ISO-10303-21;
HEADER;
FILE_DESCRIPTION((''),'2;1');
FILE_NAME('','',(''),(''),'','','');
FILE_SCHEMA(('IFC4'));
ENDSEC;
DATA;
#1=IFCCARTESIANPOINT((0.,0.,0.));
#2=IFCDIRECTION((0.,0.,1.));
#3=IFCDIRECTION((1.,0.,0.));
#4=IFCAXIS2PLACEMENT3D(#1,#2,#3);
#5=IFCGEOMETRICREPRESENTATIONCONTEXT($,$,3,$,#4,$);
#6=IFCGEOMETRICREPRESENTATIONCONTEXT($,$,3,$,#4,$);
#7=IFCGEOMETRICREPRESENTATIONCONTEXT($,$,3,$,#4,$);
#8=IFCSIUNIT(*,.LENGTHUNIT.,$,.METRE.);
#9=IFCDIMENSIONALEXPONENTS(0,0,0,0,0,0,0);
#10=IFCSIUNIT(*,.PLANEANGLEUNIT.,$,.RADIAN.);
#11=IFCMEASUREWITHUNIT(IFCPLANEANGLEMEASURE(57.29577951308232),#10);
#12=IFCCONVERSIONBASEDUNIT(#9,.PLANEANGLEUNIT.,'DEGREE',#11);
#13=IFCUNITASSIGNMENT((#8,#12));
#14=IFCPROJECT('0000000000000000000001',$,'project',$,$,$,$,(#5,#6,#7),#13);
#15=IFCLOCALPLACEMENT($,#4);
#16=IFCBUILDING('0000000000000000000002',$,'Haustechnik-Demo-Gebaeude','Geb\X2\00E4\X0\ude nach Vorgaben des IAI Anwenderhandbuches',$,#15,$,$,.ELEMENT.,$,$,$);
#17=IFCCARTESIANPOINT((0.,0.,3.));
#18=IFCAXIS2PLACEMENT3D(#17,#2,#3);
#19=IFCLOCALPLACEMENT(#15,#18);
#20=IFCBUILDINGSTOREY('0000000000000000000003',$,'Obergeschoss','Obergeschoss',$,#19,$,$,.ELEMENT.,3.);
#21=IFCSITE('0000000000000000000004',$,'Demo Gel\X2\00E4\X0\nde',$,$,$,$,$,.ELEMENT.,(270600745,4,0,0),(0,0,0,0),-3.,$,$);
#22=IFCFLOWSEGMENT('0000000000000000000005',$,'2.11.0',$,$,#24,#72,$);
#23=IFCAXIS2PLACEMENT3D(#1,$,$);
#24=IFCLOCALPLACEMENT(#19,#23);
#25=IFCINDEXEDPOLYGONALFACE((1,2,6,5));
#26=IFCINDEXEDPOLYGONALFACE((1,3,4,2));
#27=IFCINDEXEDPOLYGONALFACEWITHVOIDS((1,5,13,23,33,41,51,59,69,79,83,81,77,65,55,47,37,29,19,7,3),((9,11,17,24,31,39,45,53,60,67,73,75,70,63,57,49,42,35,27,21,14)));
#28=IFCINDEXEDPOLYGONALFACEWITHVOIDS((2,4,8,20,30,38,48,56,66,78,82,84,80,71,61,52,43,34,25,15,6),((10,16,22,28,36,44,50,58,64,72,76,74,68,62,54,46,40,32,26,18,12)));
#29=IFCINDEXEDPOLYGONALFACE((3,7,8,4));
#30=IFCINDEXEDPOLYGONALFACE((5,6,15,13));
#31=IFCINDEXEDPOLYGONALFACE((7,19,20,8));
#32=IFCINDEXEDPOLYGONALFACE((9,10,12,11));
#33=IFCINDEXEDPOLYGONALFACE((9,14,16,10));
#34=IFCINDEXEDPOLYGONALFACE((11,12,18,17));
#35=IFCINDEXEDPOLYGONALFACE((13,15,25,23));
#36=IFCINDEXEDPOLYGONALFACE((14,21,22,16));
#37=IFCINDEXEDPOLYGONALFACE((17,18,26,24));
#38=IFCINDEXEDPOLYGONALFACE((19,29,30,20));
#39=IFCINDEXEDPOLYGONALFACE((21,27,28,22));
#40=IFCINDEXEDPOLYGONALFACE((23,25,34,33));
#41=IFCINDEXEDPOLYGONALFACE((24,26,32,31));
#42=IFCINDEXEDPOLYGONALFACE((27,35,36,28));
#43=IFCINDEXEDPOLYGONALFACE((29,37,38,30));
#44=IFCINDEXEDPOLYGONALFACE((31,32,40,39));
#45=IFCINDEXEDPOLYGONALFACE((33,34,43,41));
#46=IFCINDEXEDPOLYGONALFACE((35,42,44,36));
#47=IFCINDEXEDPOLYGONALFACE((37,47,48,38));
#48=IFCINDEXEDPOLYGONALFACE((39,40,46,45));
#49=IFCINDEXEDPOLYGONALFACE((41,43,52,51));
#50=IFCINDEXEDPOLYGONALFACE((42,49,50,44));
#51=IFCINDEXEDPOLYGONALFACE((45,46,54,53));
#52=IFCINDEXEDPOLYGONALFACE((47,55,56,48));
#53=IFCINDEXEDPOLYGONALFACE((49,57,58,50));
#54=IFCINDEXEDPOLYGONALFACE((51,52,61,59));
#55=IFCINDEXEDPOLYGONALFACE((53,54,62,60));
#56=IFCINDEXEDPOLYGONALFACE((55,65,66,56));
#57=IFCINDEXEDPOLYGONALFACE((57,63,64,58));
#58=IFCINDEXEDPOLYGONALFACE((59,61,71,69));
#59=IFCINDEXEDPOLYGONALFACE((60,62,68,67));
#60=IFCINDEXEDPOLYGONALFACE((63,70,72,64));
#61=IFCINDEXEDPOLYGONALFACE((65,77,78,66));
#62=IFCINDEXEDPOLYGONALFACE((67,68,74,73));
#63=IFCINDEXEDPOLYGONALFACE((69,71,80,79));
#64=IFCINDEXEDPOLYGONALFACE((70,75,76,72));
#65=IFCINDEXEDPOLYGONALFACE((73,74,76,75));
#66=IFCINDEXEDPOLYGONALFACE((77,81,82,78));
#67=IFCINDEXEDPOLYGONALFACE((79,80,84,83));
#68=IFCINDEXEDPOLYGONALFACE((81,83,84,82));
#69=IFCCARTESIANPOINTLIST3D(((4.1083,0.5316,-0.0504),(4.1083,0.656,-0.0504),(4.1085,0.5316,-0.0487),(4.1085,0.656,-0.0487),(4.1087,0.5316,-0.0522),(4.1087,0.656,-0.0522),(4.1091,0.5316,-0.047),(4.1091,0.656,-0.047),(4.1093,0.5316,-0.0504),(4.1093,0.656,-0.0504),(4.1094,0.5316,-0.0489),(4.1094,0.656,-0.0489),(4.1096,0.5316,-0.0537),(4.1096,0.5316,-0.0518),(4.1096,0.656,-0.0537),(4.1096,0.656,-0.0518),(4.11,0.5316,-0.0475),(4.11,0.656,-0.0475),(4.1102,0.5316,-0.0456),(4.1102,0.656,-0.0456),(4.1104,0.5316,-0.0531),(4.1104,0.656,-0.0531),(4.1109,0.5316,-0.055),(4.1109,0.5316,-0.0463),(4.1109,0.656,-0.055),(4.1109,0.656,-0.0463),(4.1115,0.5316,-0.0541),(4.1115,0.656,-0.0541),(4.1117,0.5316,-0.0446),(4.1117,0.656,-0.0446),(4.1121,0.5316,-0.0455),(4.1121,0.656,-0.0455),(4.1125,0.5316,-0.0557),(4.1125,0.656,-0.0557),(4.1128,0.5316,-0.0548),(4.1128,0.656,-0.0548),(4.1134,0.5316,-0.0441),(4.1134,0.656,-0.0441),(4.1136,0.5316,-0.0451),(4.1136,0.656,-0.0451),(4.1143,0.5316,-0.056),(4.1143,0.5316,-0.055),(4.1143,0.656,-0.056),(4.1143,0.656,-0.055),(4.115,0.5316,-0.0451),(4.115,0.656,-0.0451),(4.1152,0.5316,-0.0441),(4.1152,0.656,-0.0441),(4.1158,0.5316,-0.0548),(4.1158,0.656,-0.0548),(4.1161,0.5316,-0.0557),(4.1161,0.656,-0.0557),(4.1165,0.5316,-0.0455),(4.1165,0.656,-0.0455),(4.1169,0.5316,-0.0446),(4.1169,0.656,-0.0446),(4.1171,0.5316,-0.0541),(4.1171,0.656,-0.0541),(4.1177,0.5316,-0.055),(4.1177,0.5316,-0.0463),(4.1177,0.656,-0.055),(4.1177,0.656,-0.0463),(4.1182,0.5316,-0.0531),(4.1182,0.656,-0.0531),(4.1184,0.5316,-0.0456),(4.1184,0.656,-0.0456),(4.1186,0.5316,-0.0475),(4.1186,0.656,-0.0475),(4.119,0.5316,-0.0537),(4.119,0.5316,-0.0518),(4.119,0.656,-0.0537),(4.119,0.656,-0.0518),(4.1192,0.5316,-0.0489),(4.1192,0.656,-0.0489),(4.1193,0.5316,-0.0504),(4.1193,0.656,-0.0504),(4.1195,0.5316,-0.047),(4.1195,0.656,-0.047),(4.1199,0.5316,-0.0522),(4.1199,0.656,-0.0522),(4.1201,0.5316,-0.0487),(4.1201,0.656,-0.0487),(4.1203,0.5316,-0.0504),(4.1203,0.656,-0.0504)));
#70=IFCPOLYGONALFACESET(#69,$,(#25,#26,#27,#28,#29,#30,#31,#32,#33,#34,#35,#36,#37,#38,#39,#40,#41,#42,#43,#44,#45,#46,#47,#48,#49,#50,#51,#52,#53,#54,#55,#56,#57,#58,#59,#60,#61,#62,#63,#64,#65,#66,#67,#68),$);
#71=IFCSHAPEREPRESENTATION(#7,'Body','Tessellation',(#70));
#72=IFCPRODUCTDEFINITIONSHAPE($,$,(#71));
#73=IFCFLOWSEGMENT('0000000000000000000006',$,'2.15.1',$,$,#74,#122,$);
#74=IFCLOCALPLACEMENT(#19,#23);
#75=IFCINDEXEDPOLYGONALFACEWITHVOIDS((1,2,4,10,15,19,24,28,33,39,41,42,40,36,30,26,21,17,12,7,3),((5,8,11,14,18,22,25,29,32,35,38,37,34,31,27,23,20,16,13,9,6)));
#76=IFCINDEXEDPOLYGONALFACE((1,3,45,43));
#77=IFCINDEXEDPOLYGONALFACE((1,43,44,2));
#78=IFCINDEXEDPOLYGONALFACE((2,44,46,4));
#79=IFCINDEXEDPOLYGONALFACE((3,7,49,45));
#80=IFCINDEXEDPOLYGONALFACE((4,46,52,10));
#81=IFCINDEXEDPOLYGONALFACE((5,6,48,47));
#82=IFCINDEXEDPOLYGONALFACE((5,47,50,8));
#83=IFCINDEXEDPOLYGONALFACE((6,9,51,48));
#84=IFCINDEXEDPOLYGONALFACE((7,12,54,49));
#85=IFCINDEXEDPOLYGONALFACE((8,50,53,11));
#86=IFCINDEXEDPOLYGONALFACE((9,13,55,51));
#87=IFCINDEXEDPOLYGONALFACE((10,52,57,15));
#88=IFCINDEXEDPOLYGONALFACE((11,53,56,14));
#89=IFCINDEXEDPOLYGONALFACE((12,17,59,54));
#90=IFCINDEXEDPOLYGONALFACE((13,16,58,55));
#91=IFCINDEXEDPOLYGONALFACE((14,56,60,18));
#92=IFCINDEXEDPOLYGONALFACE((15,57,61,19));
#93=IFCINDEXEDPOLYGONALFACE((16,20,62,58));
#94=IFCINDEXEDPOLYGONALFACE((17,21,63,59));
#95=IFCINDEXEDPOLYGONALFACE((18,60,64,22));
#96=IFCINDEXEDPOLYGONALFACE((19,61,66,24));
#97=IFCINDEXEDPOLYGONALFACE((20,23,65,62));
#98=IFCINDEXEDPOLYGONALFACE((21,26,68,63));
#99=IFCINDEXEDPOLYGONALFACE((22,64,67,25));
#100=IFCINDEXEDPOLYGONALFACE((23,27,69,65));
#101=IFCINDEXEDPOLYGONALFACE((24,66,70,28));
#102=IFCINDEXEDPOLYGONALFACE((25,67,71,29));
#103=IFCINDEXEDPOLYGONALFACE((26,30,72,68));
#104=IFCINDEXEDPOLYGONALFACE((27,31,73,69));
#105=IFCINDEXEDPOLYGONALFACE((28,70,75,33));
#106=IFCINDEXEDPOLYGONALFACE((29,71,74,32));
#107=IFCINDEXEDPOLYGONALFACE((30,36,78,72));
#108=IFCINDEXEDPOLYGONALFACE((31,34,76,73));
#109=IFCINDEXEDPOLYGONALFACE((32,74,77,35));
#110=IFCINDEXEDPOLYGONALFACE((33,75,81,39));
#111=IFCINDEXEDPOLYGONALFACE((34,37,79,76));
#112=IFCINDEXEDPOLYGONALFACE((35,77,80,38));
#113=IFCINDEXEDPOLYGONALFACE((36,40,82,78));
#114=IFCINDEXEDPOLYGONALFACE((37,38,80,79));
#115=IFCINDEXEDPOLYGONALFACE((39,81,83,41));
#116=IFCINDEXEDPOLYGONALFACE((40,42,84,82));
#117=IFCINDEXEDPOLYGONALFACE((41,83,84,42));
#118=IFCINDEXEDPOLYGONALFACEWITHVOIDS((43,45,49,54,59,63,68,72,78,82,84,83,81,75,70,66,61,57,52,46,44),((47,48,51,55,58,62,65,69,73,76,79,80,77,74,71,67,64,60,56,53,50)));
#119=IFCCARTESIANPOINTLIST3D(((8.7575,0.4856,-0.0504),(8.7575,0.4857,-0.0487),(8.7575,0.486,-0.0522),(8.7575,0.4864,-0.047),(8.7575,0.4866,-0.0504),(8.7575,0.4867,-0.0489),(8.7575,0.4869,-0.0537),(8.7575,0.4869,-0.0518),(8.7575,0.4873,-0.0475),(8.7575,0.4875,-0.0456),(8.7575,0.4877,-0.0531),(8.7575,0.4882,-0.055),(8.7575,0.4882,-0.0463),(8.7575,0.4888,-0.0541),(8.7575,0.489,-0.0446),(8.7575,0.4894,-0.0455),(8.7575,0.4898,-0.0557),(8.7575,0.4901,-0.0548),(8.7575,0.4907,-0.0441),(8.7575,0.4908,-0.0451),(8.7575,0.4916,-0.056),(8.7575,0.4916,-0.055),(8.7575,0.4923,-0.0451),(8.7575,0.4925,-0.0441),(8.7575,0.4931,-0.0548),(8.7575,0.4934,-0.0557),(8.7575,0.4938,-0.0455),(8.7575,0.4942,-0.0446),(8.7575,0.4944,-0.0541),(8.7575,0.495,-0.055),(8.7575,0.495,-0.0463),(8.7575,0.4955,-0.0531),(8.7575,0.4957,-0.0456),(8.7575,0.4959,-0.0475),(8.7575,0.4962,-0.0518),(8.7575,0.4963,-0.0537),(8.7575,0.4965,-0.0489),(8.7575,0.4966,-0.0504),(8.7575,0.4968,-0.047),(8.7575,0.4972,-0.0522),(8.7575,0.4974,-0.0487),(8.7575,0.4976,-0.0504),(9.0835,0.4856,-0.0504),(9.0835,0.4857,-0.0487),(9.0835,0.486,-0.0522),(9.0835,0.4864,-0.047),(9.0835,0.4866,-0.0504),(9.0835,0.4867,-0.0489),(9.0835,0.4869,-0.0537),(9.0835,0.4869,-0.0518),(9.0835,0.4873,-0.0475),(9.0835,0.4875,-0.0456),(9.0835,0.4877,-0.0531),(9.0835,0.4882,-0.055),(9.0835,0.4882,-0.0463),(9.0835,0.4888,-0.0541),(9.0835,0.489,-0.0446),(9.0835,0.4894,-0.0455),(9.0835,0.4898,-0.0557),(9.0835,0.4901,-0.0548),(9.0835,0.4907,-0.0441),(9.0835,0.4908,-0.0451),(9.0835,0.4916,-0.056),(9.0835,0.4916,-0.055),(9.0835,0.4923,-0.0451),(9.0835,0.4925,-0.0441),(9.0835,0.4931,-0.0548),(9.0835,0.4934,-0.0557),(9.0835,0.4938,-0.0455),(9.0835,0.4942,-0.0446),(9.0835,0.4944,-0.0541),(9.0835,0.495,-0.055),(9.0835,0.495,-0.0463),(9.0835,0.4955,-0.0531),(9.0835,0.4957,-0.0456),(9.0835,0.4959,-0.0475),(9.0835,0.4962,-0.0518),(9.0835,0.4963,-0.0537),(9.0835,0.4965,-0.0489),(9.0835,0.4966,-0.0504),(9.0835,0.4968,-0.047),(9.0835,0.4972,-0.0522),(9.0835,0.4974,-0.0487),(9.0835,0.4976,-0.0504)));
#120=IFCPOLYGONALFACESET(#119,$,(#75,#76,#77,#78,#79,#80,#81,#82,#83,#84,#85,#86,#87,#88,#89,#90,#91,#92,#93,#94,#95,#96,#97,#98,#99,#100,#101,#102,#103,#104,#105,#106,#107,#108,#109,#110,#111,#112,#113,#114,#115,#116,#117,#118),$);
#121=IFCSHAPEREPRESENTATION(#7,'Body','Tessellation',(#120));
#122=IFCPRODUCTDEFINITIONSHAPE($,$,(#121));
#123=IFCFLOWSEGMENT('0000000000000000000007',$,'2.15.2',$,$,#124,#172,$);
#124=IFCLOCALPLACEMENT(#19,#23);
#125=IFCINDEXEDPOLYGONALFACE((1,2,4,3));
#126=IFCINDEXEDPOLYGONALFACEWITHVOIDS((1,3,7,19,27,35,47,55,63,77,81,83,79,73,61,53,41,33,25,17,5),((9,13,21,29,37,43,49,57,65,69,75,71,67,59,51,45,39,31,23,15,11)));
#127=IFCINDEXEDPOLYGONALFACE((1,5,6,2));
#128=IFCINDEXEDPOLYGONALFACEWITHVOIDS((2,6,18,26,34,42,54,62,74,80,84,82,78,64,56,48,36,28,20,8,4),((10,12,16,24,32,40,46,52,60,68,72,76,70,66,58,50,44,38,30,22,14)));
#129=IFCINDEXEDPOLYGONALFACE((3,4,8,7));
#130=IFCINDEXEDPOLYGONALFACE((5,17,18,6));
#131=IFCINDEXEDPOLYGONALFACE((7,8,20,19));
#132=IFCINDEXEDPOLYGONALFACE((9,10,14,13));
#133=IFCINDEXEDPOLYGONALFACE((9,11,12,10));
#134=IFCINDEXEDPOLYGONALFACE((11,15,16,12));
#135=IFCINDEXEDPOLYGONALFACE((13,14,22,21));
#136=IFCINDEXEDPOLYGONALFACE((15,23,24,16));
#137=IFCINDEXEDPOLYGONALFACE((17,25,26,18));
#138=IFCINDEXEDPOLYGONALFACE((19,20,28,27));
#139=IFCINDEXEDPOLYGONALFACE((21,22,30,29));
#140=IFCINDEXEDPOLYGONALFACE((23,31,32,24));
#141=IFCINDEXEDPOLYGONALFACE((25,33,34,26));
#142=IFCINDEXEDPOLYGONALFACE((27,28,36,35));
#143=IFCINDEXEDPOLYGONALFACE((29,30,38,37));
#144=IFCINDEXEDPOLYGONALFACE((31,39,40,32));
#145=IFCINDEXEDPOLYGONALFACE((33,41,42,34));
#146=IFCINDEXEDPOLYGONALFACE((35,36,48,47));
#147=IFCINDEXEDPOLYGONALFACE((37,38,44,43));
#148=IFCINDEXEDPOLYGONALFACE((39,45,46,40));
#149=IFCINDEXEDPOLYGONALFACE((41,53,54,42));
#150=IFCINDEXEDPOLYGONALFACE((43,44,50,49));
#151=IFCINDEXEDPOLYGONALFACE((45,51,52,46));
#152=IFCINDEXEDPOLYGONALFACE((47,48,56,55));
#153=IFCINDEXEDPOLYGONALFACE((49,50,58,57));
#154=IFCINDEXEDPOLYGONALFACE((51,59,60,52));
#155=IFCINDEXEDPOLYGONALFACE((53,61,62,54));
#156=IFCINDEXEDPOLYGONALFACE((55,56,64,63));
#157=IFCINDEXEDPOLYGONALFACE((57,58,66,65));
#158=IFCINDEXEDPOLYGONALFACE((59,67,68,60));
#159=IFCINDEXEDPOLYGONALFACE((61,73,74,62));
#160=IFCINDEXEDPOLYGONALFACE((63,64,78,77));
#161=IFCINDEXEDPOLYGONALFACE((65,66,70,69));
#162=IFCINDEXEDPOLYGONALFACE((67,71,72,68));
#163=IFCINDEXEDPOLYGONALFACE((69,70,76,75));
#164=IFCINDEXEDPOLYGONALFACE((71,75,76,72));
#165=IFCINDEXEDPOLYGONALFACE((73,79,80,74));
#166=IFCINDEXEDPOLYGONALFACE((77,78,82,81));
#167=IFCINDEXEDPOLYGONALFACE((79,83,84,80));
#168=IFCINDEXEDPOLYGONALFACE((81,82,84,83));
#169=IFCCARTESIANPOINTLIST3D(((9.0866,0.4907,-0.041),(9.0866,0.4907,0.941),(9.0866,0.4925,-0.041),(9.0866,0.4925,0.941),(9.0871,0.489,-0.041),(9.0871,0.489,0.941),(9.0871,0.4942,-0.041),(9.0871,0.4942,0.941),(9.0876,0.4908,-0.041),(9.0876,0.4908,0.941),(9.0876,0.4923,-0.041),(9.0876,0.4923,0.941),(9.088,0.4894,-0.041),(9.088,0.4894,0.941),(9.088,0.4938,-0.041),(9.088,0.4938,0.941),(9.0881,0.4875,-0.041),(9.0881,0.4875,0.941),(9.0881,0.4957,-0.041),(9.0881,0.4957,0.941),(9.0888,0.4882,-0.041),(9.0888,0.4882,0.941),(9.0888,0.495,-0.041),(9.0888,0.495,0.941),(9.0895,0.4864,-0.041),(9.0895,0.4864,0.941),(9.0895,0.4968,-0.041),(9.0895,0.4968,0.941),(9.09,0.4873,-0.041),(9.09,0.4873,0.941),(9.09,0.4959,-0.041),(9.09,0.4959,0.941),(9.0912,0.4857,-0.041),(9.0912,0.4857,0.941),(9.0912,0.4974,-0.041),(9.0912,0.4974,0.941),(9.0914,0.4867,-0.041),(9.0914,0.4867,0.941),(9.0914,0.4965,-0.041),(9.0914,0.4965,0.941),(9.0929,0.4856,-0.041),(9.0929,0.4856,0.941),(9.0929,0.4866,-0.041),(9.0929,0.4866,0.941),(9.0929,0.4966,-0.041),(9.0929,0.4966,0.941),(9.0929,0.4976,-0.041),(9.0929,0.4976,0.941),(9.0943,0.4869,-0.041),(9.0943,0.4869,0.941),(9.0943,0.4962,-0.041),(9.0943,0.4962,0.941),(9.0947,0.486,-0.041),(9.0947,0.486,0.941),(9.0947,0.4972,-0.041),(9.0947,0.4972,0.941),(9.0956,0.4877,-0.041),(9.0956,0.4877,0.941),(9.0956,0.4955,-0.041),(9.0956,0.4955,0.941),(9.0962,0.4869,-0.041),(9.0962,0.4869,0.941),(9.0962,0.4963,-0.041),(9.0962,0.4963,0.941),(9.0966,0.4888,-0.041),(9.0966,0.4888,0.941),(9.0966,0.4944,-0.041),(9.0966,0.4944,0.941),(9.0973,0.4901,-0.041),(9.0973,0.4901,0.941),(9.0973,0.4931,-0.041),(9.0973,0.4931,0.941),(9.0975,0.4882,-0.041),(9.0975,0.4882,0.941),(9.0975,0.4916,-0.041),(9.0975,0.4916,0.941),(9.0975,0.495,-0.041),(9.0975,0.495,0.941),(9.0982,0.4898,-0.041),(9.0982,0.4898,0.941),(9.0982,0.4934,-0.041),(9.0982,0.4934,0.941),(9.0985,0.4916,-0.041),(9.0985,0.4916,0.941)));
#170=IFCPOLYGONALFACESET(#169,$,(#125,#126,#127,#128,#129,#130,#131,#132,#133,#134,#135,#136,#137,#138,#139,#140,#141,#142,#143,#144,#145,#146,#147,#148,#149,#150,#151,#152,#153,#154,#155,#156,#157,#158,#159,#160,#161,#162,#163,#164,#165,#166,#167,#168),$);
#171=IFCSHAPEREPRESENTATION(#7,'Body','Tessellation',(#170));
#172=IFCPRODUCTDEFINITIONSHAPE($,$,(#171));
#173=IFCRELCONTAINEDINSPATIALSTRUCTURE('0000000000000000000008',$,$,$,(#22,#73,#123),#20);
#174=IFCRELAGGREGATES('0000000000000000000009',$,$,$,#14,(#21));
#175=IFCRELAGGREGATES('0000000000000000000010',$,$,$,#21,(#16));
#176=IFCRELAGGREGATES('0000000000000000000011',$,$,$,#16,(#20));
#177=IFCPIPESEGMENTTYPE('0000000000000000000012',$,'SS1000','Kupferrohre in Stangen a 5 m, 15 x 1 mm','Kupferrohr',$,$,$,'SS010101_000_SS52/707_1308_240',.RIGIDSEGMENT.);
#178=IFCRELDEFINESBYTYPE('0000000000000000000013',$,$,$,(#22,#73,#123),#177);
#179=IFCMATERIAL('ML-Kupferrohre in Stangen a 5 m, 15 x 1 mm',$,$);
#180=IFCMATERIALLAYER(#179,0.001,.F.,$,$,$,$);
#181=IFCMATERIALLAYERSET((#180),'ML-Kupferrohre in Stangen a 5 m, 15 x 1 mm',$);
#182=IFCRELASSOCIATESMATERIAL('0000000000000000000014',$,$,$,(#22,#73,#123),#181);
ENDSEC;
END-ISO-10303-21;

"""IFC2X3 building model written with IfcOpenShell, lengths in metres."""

from ifc_helpers import new_model, entity, si_unit, converted_unit, frame, origin_with_axes, origin_2d_with_axis, place, context, project, spatial, hollow_circle, extrude, material, layer, layer_set, layer_usage, type_object, element, save


model = new_model("IFC2X3")

# Units and contexts
context_of_model_1 = context(None, 3, world=origin_with_axes())
context_of_model_2 = context(None, 3, world=origin_with_axes())
context_of_model_3 = context(None, 3, world=origin_with_axes())
ifc_project = project(units=[si_unit("LENGTHUNIT", "METRE"), converted_unit("PLANEANGLEUNIT", "DEGREE", entity("IfcPlaneAngleMeasure", 57.29577951308232), si_unit("PLANEANGLEUNIT", "RADIAN"), dimensions=[0, 0, 0, 0, 0, 0, 0])], contexts=[context_of_model_1, context_of_model_2, context_of_model_3])

# Site, building, storey
site = spatial("IfcSite", under=ifc_project, Name="Demo Gelände", CompositionType="ELEMENT", RefLatitude=(270600745, 4, 0, 0), RefLongitude=(0, 0, 0, 0), RefElevation=-3.0)
building_placement = place(None, origin_with_axes())
building = spatial("IfcBuilding", under=site, at=building_placement, Name="Haustechnik-Demo-Gebaeude", Description="Gebäude nach Vorgaben des IAI Anwenderhandbuches", CompositionType="ELEMENT")
storey_placement = place(building_placement, frame((0.0, 0.0, 3.0), z_axis=(0.0, 0.0, 1.0), x_axis=(1.0, 0.0, 0.0)))
storey = spatial("IfcBuildingStorey", under=building, at=storey_placement, Name="Obergeschoss", Description="Obergeschoss", CompositionType="ELEMENT", Elevation=3.0)

# Flow segments
ifc_material = material(Name="ML-Kupferrohre in Stangen a 5 m, 15 x 1 mm")
ifc_layer = layer(ifc_material, 0.001, ventilated=False)
ifc_layer_set = layer_set([ifc_layer], Name="ML-Kupferrohre in Stangen a 5 m, 15 x 1 mm")
ifc_layer_usage = layer_usage(ifc_layer_set, "AXIS2", "POSITIVE", 0.0)
pipe_segment_type_1 = type_object("IfcPipeSegmentType", Name="SS1000", Description="Kupferrohre in Stangen a 5 m, 15 x 1 mm", ApplicableOccurrence="Kupferrohr", ElementType="SS010101_000_SS52/707_1308_240", PredefinedType="RIGIDSEGMENT")
flow_segment_1_placement = place(storey_placement, frame((4.1143, 0.656, -0.05), z_axis=(0.0, -1.0, 0.0), x_axis=(0.0, 0.0, -1.0)))
element("IfcFlowSegment", 1, at=flow_segment_1_placement, inside=storey, type_object=pipe_segment_type_1, material=ifc_layer_usage, Name="2.11.0", context=context_of_model_3, shape_type="SweptSolid", body=[
    extrude(hollow_circle(Radius=0.006, WallThickness=0.001, at=origin_2d_with_axis()), origin_with_axes(), (0.0, 0.0, 1.0), 0.1244),
])
flow_segment_2_placement = place(storey_placement, frame((8.7575, 0.4916, -0.05), z_axis=(1.0, 0.0, 0.0), x_axis=(0.0, 0.0, -1.0)))
element("IfcFlowSegment", 2, at=flow_segment_2_placement, inside=storey, type_object=pipe_segment_type_1, material=ifc_layer_usage, Name="2.15.1", context=context_of_model_3, shape_type="SweptSolid", body=[
    extrude(hollow_circle(Radius=0.006, WallThickness=0.001, at=origin_2d_with_axis()), origin_with_axes(), (0.0, 0.0, 1.0), 0.326),
])
flow_segment_3_placement = place(storey_placement, frame((9.0925, 0.4916, -0.041), z_axis=(0.0, 0.0, 1.0), x_axis=(1.0, 0.0, 0.0)))
element("IfcFlowSegment", 3, at=flow_segment_3_placement, inside=storey, type_object=pipe_segment_type_1, material=ifc_layer_usage, Name="2.15.2", context=context_of_model_3, shape_type="SweptSolid", body=[
    extrude(hollow_circle(Radius=0.006, WallThickness=0.001, at=origin_2d_with_axis()), origin_with_axes(), (0.0, 0.0, 1.0), 0.982),
])

save(model, "model.ifc")
